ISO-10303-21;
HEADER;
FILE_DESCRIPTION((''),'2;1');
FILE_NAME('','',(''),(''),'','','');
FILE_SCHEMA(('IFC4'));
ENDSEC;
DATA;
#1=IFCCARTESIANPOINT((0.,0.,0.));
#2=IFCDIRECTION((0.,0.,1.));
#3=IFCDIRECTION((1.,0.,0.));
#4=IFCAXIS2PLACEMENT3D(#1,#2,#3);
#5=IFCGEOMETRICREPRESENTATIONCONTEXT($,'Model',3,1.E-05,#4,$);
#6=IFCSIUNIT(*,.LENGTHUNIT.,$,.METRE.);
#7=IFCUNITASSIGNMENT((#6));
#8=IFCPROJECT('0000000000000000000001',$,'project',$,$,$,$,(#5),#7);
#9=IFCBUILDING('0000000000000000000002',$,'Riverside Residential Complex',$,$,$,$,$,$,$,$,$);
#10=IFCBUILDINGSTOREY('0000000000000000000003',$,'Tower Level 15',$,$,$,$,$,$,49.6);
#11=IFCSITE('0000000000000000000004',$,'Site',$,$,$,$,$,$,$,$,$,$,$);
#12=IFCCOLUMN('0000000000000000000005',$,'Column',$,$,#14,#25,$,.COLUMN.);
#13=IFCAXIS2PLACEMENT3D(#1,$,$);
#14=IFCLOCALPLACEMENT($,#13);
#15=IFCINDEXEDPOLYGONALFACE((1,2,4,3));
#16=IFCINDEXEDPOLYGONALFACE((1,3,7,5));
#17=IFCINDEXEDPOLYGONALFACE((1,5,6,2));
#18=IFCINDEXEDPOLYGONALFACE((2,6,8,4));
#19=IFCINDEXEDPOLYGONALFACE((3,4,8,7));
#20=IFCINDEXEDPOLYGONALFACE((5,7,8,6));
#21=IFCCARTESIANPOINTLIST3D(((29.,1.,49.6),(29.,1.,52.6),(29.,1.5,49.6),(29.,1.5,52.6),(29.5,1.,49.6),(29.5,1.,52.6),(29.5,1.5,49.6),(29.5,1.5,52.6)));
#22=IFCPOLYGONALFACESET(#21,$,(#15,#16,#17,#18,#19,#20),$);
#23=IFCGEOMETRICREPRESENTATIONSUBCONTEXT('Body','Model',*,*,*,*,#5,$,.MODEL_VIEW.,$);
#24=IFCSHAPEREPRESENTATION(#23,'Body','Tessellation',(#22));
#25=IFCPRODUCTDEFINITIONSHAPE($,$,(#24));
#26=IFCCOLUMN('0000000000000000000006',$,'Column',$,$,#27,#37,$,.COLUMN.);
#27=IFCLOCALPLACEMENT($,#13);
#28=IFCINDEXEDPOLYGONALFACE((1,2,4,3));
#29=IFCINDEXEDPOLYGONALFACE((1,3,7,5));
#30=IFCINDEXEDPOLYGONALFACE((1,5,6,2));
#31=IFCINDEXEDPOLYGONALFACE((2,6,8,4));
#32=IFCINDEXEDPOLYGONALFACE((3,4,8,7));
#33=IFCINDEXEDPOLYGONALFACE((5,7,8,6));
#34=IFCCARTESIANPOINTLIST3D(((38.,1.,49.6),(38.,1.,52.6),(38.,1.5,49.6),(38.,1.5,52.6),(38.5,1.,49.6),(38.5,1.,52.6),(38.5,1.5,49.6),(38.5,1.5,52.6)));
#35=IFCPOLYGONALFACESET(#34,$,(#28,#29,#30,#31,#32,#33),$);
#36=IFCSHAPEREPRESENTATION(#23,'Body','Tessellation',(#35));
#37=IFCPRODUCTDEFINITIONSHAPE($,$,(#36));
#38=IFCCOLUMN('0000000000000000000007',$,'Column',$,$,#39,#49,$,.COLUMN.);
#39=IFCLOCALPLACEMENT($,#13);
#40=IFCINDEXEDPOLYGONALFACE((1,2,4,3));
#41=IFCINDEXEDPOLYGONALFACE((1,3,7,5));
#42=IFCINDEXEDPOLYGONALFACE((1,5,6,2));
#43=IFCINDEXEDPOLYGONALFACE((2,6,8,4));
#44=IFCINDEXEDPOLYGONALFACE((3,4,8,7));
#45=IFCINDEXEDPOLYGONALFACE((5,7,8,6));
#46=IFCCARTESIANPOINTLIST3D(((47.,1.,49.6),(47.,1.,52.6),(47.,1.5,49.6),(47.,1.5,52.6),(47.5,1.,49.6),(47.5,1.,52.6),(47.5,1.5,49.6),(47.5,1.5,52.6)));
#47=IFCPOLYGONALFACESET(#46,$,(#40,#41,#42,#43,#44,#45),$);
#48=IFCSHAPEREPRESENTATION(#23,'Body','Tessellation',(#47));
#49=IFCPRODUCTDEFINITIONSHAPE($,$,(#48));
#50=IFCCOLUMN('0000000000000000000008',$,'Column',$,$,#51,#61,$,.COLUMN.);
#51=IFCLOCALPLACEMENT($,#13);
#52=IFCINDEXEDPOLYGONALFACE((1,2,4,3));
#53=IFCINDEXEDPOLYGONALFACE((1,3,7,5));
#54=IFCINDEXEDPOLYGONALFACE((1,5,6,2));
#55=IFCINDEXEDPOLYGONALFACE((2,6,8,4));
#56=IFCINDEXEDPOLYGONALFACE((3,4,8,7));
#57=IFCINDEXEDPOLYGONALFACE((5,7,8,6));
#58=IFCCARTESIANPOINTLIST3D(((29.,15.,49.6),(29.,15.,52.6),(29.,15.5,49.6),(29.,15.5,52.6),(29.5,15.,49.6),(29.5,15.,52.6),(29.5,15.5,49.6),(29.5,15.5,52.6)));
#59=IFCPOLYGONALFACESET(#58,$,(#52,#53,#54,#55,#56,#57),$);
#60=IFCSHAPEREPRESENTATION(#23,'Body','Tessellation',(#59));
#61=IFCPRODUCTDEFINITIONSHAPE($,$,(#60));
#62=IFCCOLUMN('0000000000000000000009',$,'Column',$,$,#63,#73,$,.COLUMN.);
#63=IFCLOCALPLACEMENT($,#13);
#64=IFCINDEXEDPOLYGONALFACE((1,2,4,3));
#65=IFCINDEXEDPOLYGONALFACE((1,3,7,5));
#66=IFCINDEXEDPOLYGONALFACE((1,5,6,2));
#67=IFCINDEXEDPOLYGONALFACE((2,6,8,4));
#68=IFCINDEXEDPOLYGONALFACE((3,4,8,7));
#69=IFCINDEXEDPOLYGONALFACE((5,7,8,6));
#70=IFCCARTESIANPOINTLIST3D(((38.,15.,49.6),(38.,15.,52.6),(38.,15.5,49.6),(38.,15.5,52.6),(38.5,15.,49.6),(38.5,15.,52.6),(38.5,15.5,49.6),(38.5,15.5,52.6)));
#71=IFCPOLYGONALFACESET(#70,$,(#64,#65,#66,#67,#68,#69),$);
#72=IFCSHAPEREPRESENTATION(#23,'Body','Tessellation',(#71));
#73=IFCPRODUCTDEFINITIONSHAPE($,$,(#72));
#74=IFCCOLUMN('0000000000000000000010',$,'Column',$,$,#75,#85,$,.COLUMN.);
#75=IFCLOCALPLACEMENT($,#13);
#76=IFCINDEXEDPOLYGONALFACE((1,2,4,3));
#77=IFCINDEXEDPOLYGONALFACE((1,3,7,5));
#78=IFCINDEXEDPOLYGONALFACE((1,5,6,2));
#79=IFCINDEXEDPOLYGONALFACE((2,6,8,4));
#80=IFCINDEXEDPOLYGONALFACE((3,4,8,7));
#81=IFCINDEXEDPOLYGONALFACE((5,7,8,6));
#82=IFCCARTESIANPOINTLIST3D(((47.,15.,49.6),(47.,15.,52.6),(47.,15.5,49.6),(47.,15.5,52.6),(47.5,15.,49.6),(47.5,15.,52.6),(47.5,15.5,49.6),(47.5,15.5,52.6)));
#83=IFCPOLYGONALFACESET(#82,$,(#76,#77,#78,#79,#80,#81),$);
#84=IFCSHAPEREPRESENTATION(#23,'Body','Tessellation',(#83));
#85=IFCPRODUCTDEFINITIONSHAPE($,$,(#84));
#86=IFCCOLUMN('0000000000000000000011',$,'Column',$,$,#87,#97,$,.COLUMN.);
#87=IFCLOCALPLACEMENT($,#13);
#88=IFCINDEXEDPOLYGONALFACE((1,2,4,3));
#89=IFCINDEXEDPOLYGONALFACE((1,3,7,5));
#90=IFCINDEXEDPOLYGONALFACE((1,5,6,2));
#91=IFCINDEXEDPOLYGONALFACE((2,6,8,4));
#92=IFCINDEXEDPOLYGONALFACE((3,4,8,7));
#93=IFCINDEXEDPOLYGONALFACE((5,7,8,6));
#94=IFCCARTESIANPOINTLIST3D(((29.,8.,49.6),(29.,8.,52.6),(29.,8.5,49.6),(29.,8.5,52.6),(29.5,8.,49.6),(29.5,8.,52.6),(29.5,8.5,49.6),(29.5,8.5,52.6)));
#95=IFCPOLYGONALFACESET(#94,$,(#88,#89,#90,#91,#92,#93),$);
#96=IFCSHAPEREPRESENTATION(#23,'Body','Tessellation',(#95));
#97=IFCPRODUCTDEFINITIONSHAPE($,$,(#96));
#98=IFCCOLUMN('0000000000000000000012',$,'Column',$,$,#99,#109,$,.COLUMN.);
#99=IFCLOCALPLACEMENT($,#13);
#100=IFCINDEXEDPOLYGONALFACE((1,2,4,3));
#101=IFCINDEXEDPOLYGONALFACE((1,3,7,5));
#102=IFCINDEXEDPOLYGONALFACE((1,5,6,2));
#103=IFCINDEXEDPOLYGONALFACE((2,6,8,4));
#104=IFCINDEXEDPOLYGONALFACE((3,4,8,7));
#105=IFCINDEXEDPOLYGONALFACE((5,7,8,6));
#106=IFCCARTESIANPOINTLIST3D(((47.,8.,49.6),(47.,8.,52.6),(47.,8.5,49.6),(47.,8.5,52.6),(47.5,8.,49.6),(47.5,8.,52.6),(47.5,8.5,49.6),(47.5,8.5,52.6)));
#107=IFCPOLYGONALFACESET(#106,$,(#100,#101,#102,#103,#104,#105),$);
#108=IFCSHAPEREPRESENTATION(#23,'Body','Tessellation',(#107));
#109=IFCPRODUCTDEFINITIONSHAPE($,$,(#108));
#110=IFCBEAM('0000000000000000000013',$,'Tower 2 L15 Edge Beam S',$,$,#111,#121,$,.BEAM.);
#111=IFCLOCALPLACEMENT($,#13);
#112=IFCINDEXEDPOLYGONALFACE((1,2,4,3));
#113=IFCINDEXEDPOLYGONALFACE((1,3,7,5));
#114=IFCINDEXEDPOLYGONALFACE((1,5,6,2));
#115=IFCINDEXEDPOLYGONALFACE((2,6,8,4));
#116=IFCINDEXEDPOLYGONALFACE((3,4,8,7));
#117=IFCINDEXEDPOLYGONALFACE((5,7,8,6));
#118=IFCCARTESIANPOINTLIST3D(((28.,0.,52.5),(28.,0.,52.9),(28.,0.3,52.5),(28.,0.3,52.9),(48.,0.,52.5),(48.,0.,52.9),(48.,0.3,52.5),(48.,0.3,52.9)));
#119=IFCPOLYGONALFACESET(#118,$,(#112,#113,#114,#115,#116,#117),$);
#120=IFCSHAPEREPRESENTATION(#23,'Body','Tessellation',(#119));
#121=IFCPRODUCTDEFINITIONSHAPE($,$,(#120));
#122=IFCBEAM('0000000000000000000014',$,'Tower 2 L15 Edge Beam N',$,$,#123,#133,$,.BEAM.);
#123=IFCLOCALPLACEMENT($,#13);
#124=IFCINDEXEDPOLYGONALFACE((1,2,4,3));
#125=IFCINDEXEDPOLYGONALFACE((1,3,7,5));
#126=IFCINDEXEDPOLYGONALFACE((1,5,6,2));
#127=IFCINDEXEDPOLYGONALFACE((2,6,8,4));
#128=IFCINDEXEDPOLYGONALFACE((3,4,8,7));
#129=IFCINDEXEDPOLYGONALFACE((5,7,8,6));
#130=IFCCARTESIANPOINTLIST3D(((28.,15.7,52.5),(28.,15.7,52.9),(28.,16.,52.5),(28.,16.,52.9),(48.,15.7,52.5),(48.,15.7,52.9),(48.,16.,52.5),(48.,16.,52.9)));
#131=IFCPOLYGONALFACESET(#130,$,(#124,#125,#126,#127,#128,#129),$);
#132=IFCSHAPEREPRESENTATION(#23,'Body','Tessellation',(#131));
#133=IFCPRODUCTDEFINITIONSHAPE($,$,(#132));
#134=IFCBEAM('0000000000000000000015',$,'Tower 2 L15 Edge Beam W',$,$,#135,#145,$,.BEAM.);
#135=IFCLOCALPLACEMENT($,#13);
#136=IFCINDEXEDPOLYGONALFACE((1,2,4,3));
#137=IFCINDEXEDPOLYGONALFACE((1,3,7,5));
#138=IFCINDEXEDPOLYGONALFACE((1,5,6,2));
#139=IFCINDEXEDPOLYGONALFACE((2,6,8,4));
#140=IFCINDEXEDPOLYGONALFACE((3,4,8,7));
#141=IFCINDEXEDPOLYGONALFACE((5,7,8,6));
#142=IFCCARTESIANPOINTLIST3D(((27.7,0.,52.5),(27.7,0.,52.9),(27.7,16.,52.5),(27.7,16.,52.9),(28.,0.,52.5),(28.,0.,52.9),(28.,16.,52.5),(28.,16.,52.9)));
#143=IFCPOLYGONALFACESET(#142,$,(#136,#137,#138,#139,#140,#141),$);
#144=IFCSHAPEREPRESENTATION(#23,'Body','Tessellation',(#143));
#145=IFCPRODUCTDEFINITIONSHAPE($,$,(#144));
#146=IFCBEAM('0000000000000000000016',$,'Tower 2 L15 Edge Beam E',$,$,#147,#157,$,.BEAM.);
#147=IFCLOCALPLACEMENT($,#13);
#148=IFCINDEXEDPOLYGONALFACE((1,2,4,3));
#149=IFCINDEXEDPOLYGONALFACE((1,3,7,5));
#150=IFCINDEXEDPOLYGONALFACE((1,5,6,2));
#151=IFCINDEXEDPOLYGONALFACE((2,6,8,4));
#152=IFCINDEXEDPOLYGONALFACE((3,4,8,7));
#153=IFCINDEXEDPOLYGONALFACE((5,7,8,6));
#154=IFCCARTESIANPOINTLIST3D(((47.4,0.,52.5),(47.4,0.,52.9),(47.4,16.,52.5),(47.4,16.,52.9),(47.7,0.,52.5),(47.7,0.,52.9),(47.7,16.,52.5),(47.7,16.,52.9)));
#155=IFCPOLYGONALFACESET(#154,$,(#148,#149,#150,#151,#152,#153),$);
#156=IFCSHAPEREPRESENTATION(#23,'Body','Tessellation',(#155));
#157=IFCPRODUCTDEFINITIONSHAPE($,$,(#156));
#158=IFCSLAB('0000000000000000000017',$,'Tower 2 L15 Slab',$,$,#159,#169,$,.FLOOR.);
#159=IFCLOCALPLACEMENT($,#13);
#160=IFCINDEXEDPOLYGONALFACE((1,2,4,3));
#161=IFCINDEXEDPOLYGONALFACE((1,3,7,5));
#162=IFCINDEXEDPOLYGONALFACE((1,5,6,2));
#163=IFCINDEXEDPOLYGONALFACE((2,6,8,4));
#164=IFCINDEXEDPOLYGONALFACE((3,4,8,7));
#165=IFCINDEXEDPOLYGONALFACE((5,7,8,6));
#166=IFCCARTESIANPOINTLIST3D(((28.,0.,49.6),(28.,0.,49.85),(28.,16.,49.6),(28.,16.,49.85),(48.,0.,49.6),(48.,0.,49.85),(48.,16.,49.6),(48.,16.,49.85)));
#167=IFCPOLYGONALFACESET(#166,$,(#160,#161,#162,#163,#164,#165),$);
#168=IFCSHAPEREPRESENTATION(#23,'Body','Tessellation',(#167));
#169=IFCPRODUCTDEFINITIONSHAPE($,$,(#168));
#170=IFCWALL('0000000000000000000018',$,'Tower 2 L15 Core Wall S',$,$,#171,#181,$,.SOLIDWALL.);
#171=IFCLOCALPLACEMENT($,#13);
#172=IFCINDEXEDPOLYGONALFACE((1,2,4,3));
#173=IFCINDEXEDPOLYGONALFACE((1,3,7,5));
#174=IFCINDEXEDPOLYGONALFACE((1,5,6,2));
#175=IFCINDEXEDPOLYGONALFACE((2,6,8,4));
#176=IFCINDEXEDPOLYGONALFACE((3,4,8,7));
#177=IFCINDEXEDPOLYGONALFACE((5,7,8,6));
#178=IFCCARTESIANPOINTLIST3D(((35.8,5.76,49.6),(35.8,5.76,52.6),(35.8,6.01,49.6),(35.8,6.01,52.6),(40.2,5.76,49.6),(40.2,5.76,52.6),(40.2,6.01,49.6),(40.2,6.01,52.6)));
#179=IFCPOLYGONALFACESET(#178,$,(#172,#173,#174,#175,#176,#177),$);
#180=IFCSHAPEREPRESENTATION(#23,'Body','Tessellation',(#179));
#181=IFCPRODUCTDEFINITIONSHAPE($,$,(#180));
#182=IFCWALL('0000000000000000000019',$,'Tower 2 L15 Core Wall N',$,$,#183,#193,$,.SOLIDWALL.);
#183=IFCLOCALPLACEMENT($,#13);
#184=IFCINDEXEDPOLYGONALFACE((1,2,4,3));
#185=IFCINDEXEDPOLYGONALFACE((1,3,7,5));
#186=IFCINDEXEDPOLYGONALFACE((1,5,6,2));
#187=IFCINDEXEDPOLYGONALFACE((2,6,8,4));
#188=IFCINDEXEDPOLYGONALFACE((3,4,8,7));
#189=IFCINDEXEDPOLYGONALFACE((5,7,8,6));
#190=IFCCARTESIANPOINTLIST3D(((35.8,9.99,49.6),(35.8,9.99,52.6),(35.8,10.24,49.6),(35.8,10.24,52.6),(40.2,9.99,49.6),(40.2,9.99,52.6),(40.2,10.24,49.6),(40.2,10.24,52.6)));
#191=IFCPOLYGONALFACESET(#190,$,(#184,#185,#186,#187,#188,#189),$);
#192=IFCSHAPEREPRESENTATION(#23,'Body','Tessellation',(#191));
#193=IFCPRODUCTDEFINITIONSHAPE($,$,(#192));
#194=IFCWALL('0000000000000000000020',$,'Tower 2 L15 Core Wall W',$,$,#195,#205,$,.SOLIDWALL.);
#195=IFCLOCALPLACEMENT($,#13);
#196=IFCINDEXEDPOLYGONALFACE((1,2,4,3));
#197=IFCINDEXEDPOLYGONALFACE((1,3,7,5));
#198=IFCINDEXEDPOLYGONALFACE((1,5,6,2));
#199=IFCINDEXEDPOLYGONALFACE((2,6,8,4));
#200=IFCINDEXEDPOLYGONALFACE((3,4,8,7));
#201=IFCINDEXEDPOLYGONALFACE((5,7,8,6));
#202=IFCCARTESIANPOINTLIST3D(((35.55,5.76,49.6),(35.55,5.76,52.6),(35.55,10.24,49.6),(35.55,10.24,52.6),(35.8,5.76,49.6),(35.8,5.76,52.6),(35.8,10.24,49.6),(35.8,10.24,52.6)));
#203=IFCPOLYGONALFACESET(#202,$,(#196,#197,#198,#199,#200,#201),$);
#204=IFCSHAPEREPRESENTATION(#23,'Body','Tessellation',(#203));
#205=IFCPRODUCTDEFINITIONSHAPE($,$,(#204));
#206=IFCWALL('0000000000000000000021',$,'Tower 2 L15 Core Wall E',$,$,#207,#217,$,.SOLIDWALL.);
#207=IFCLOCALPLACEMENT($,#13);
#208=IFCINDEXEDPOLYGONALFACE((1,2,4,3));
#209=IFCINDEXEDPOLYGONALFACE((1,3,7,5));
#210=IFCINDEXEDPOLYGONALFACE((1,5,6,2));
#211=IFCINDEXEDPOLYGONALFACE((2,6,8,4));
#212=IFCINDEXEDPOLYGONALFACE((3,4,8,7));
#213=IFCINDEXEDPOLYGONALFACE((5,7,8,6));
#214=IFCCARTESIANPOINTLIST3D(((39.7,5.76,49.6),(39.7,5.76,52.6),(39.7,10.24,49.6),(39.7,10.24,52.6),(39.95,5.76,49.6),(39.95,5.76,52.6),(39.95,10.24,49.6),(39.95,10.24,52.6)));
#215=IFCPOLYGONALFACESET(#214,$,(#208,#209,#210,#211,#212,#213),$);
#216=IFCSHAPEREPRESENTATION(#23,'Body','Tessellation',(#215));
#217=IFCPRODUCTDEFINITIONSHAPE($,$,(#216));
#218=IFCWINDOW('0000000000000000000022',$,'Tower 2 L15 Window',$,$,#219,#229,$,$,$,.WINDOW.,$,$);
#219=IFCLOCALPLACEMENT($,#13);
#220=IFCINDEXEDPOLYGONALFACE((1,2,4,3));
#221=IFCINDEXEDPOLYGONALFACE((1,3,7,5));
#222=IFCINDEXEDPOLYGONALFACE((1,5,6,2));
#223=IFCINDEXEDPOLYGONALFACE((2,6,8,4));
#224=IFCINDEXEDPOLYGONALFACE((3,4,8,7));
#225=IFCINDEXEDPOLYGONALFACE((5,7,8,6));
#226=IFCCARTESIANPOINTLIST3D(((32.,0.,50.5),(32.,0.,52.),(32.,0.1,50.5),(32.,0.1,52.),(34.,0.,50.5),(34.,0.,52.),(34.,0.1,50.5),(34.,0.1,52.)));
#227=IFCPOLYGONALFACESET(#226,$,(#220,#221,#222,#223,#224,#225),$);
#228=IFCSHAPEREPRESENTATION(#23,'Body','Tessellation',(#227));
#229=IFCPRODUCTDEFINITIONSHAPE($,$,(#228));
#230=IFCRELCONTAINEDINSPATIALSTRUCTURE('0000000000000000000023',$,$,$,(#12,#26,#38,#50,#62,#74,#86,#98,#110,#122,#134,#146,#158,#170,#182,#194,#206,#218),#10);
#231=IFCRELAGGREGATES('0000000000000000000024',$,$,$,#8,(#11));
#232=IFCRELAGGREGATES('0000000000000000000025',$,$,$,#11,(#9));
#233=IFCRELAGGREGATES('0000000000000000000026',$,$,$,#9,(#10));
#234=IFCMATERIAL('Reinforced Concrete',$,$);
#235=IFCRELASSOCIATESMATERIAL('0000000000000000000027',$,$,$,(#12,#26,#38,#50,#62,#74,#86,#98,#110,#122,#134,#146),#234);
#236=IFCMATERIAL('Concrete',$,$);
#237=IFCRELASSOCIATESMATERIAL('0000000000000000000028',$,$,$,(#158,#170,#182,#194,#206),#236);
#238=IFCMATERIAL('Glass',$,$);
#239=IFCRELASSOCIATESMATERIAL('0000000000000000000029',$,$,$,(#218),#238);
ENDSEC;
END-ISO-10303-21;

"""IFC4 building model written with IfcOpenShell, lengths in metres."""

from ifc_helpers import new_model, si_unit, frame, origin_with_axes, place, context, subcontext, project, spatial, line, indexed_curve, outline, extrude, material, element, save


model = new_model("IFC4")

# Units and contexts
model_context = context("Model", 3, precision=1e-05, world=origin_with_axes())
body_context = subcontext(model_context, "Body", "Model", "MODEL_VIEW")
ifc_project = project(units=[si_unit("LENGTHUNIT", "METRE")], contexts=[model_context])

# Site, building, storey
site = spatial("IfcSite", under=ifc_project, Name="Site")
building = spatial("IfcBuilding", under=site, Name="Riverside Residential Complex")
storey = spatial("IfcBuildingStorey", under=building, Name="Tower Level 15", Elevation=49.6)

# Columns
ifc_material_1 = material(Name="Reinforced Concrete")
for number, where, z_axis, x_axis, name in (
    (1, (29.0, 1.0, 49.6), (0.0, 0.0, 1.0), (1.0, 0.0, 0.0), "Column"),
    (2, (38.0, 1.0, 49.6), (0.0, 0.0, 1.0), (1.0, 0.0, 0.0), "Column"),
    (3, (47.0, 1.0, 49.6), (0.0, 0.0, 1.0), (1.0, 0.0, 0.0), "Column"),
    (4, (29.0, 15.0, 49.6), (0.0, 0.0, 1.0), (1.0, 0.0, 0.0), "Column"),
    (5, (38.0, 15.0, 49.6), (0.0, 0.0, 1.0), (1.0, 0.0, 0.0), "Column"),
    (6, (47.0, 15.0, 49.6), (0.0, 0.0, 1.0), (1.0, 0.0, 0.0), "Column"),
    (7, (29.0, 8.0, 49.6), (0.0, 0.0, 1.0), (1.0, 0.0, 0.0), "Column"),
    (8, (47.0, 8.0, 49.6), (0.0, 0.0, 1.0), (1.0, 0.0, 0.0), "Column"),
):
    element("IfcColumn", number, at=place(None, frame(where, z_axis=z_axis, x_axis=x_axis)), inside=storey, material=ifc_material_1, Name=name, PredefinedType="COLUMN", context=body_context, shape_type="SweptSolid", body=[
        extrude(outline(indexed_curve([(0.0, 0.0), (0.5, 0.0), (0.5, 0.5), (0.0, 0.5)], segments=[line(1, 2, 3, 4, 1)])), origin_with_axes(), (0.0, 0.0, 1.0), 3.0),
    ])

# Beams
for number, where, z_axis, x_axis, name in (
    (9, (28.0, 0.0, 52.5), (0.0, 0.0, 1.0), (1.0, 0.0, 0.0), "Tower 2 L15 Edge Beam S"),
    (10, (28.0, 15.7, 52.5), (0.0, 0.0, 1.0), (1.0, 0.0, 0.0), "Tower 2 L15 Edge Beam N"),
):
    element("IfcBeam", number, at=place(None, frame(where, z_axis=z_axis, x_axis=x_axis)), inside=storey, material=ifc_material_1, Name=name, PredefinedType="BEAM", context=body_context, shape_type="SweptSolid", body=[
        extrude(outline(indexed_curve([(0.0, 0.0), (20.0, 0.0), (20.0, 0.3), (0.0, 0.3)], segments=[line(1, 2, 3, 4, 1)])), origin_with_axes(), (0.0, 0.0, 1.0), 0.4),
    ])
for number, where, z_axis, x_axis, name in (
    (11, (28.0, 0.0, 52.5), (0.0, 0.0, 1.0), (0.0, 1.0, 0.0), "Tower 2 L15 Edge Beam W"),
    (12, (47.7, 0.0, 52.5), (0.0, 0.0, 1.0), (0.0, 1.0, 0.0), "Tower 2 L15 Edge Beam E"),
):
    element("IfcBeam", number, at=place(None, frame(where, z_axis=z_axis, x_axis=x_axis)), inside=storey, material=ifc_material_1, Name=name, PredefinedType="BEAM", context=body_context, shape_type="SweptSolid", body=[
        extrude(outline(indexed_curve([(0.0, 0.0), (16.0, 0.0), (16.0, 0.3), (0.0, 0.3)], segments=[line(1, 2, 3, 4, 1)])), origin_with_axes(), (0.0, 0.0, 1.0), 0.4),
    ])

# Slab
ifc_material_2 = material(Name="Concrete")
slab_placement = place(None, frame((28.0, 0.0, 49.6), z_axis=(0.0, 0.0, 1.0), x_axis=(1.0, 0.0, 0.0)))
element("IfcSlab", 13, at=slab_placement, inside=storey, material=ifc_material_2, Name="Tower 2 L15 Slab", PredefinedType="FLOOR", context=body_context, shape_type="SweptSolid", body=[
    extrude(outline(indexed_curve([(0.0, 0.0), (20.0, 0.0), (20.0, 16.0), (0.0, 16.0)], segments=[line(1, 2, 3, 4, 1)])), origin_with_axes(), (0.0, 0.0, 1.0), 0.25),
])

# Walls
for number, where, z_axis, x_axis, name in (
    (14, (35.8, 5.76, 49.6), (0.0, 0.0, 1.0), (1.0, 0.0, 0.0), "Tower 2 L15 Core Wall S"),
    (15, (35.8, 9.99, 49.6), (0.0, 0.0, 1.0), (1.0, 0.0, 0.0), "Tower 2 L15 Core Wall N"),
):
    element("IfcWall", number, at=place(None, frame(where, z_axis=z_axis, x_axis=x_axis)), inside=storey, material=ifc_material_2, Name=name, PredefinedType="SOLIDWALL", context=body_context, shape_type="SweptSolid", body=[
        extrude(outline(indexed_curve([(0.0, 0.0), (4.4, 0.0), (4.4, 0.25), (0.0, 0.25)], segments=[line(1, 2, 3, 4, 1)])), origin_with_axes(), (0.0, 0.0, 1.0), 3.0),
    ])
for number, where, z_axis, x_axis, name in (
    (16, (35.8, 5.76, 49.6), (0.0, 0.0, 1.0), (0.0, 1.0, 0.0), "Tower 2 L15 Core Wall W"),
    (17, (39.95, 5.76, 49.6), (0.0, 0.0, 1.0), (0.0, 1.0, 0.0), "Tower 2 L15 Core Wall E"),
):
    element("IfcWall", number, at=place(None, frame(where, z_axis=z_axis, x_axis=x_axis)), inside=storey, material=ifc_material_2, Name=name, PredefinedType="SOLIDWALL", context=body_context, shape_type="SweptSolid", body=[
        extrude(outline(indexed_curve([(0.0, 0.0), (4.48, 0.0), (4.48, 0.25), (0.0, 0.25)], segments=[line(1, 2, 3, 4, 1)])), origin_with_axes(), (0.0, 0.0, 1.0), 3.0),
    ])

# Window
ifc_material_3 = material(Name="Glass")
for number, where, z_axis, x_axis, name in (
    (18, (32.0, 0.0, 50.5), (0.0, 0.0, 1.0), (1.0, 0.0, 0.0), "Tower 2 L15 Window"),
):
    element("IfcWindow", number, at=place(None, frame(where, z_axis=z_axis, x_axis=x_axis)), inside=storey, material=ifc_material_3, Name=name, PredefinedType="WINDOW", context=body_context, shape_type="SweptSolid", body=[
        extrude(outline(indexed_curve([(0.0, 0.0), (2.0, 0.0), (2.0, 0.1), (0.0, 0.1)], segments=[line(1, 2, 3, 4, 1)])), origin_with_axes(), (0.0, 0.0, 1.0), 1.5),
    ])

save(model, "model.ifc")
